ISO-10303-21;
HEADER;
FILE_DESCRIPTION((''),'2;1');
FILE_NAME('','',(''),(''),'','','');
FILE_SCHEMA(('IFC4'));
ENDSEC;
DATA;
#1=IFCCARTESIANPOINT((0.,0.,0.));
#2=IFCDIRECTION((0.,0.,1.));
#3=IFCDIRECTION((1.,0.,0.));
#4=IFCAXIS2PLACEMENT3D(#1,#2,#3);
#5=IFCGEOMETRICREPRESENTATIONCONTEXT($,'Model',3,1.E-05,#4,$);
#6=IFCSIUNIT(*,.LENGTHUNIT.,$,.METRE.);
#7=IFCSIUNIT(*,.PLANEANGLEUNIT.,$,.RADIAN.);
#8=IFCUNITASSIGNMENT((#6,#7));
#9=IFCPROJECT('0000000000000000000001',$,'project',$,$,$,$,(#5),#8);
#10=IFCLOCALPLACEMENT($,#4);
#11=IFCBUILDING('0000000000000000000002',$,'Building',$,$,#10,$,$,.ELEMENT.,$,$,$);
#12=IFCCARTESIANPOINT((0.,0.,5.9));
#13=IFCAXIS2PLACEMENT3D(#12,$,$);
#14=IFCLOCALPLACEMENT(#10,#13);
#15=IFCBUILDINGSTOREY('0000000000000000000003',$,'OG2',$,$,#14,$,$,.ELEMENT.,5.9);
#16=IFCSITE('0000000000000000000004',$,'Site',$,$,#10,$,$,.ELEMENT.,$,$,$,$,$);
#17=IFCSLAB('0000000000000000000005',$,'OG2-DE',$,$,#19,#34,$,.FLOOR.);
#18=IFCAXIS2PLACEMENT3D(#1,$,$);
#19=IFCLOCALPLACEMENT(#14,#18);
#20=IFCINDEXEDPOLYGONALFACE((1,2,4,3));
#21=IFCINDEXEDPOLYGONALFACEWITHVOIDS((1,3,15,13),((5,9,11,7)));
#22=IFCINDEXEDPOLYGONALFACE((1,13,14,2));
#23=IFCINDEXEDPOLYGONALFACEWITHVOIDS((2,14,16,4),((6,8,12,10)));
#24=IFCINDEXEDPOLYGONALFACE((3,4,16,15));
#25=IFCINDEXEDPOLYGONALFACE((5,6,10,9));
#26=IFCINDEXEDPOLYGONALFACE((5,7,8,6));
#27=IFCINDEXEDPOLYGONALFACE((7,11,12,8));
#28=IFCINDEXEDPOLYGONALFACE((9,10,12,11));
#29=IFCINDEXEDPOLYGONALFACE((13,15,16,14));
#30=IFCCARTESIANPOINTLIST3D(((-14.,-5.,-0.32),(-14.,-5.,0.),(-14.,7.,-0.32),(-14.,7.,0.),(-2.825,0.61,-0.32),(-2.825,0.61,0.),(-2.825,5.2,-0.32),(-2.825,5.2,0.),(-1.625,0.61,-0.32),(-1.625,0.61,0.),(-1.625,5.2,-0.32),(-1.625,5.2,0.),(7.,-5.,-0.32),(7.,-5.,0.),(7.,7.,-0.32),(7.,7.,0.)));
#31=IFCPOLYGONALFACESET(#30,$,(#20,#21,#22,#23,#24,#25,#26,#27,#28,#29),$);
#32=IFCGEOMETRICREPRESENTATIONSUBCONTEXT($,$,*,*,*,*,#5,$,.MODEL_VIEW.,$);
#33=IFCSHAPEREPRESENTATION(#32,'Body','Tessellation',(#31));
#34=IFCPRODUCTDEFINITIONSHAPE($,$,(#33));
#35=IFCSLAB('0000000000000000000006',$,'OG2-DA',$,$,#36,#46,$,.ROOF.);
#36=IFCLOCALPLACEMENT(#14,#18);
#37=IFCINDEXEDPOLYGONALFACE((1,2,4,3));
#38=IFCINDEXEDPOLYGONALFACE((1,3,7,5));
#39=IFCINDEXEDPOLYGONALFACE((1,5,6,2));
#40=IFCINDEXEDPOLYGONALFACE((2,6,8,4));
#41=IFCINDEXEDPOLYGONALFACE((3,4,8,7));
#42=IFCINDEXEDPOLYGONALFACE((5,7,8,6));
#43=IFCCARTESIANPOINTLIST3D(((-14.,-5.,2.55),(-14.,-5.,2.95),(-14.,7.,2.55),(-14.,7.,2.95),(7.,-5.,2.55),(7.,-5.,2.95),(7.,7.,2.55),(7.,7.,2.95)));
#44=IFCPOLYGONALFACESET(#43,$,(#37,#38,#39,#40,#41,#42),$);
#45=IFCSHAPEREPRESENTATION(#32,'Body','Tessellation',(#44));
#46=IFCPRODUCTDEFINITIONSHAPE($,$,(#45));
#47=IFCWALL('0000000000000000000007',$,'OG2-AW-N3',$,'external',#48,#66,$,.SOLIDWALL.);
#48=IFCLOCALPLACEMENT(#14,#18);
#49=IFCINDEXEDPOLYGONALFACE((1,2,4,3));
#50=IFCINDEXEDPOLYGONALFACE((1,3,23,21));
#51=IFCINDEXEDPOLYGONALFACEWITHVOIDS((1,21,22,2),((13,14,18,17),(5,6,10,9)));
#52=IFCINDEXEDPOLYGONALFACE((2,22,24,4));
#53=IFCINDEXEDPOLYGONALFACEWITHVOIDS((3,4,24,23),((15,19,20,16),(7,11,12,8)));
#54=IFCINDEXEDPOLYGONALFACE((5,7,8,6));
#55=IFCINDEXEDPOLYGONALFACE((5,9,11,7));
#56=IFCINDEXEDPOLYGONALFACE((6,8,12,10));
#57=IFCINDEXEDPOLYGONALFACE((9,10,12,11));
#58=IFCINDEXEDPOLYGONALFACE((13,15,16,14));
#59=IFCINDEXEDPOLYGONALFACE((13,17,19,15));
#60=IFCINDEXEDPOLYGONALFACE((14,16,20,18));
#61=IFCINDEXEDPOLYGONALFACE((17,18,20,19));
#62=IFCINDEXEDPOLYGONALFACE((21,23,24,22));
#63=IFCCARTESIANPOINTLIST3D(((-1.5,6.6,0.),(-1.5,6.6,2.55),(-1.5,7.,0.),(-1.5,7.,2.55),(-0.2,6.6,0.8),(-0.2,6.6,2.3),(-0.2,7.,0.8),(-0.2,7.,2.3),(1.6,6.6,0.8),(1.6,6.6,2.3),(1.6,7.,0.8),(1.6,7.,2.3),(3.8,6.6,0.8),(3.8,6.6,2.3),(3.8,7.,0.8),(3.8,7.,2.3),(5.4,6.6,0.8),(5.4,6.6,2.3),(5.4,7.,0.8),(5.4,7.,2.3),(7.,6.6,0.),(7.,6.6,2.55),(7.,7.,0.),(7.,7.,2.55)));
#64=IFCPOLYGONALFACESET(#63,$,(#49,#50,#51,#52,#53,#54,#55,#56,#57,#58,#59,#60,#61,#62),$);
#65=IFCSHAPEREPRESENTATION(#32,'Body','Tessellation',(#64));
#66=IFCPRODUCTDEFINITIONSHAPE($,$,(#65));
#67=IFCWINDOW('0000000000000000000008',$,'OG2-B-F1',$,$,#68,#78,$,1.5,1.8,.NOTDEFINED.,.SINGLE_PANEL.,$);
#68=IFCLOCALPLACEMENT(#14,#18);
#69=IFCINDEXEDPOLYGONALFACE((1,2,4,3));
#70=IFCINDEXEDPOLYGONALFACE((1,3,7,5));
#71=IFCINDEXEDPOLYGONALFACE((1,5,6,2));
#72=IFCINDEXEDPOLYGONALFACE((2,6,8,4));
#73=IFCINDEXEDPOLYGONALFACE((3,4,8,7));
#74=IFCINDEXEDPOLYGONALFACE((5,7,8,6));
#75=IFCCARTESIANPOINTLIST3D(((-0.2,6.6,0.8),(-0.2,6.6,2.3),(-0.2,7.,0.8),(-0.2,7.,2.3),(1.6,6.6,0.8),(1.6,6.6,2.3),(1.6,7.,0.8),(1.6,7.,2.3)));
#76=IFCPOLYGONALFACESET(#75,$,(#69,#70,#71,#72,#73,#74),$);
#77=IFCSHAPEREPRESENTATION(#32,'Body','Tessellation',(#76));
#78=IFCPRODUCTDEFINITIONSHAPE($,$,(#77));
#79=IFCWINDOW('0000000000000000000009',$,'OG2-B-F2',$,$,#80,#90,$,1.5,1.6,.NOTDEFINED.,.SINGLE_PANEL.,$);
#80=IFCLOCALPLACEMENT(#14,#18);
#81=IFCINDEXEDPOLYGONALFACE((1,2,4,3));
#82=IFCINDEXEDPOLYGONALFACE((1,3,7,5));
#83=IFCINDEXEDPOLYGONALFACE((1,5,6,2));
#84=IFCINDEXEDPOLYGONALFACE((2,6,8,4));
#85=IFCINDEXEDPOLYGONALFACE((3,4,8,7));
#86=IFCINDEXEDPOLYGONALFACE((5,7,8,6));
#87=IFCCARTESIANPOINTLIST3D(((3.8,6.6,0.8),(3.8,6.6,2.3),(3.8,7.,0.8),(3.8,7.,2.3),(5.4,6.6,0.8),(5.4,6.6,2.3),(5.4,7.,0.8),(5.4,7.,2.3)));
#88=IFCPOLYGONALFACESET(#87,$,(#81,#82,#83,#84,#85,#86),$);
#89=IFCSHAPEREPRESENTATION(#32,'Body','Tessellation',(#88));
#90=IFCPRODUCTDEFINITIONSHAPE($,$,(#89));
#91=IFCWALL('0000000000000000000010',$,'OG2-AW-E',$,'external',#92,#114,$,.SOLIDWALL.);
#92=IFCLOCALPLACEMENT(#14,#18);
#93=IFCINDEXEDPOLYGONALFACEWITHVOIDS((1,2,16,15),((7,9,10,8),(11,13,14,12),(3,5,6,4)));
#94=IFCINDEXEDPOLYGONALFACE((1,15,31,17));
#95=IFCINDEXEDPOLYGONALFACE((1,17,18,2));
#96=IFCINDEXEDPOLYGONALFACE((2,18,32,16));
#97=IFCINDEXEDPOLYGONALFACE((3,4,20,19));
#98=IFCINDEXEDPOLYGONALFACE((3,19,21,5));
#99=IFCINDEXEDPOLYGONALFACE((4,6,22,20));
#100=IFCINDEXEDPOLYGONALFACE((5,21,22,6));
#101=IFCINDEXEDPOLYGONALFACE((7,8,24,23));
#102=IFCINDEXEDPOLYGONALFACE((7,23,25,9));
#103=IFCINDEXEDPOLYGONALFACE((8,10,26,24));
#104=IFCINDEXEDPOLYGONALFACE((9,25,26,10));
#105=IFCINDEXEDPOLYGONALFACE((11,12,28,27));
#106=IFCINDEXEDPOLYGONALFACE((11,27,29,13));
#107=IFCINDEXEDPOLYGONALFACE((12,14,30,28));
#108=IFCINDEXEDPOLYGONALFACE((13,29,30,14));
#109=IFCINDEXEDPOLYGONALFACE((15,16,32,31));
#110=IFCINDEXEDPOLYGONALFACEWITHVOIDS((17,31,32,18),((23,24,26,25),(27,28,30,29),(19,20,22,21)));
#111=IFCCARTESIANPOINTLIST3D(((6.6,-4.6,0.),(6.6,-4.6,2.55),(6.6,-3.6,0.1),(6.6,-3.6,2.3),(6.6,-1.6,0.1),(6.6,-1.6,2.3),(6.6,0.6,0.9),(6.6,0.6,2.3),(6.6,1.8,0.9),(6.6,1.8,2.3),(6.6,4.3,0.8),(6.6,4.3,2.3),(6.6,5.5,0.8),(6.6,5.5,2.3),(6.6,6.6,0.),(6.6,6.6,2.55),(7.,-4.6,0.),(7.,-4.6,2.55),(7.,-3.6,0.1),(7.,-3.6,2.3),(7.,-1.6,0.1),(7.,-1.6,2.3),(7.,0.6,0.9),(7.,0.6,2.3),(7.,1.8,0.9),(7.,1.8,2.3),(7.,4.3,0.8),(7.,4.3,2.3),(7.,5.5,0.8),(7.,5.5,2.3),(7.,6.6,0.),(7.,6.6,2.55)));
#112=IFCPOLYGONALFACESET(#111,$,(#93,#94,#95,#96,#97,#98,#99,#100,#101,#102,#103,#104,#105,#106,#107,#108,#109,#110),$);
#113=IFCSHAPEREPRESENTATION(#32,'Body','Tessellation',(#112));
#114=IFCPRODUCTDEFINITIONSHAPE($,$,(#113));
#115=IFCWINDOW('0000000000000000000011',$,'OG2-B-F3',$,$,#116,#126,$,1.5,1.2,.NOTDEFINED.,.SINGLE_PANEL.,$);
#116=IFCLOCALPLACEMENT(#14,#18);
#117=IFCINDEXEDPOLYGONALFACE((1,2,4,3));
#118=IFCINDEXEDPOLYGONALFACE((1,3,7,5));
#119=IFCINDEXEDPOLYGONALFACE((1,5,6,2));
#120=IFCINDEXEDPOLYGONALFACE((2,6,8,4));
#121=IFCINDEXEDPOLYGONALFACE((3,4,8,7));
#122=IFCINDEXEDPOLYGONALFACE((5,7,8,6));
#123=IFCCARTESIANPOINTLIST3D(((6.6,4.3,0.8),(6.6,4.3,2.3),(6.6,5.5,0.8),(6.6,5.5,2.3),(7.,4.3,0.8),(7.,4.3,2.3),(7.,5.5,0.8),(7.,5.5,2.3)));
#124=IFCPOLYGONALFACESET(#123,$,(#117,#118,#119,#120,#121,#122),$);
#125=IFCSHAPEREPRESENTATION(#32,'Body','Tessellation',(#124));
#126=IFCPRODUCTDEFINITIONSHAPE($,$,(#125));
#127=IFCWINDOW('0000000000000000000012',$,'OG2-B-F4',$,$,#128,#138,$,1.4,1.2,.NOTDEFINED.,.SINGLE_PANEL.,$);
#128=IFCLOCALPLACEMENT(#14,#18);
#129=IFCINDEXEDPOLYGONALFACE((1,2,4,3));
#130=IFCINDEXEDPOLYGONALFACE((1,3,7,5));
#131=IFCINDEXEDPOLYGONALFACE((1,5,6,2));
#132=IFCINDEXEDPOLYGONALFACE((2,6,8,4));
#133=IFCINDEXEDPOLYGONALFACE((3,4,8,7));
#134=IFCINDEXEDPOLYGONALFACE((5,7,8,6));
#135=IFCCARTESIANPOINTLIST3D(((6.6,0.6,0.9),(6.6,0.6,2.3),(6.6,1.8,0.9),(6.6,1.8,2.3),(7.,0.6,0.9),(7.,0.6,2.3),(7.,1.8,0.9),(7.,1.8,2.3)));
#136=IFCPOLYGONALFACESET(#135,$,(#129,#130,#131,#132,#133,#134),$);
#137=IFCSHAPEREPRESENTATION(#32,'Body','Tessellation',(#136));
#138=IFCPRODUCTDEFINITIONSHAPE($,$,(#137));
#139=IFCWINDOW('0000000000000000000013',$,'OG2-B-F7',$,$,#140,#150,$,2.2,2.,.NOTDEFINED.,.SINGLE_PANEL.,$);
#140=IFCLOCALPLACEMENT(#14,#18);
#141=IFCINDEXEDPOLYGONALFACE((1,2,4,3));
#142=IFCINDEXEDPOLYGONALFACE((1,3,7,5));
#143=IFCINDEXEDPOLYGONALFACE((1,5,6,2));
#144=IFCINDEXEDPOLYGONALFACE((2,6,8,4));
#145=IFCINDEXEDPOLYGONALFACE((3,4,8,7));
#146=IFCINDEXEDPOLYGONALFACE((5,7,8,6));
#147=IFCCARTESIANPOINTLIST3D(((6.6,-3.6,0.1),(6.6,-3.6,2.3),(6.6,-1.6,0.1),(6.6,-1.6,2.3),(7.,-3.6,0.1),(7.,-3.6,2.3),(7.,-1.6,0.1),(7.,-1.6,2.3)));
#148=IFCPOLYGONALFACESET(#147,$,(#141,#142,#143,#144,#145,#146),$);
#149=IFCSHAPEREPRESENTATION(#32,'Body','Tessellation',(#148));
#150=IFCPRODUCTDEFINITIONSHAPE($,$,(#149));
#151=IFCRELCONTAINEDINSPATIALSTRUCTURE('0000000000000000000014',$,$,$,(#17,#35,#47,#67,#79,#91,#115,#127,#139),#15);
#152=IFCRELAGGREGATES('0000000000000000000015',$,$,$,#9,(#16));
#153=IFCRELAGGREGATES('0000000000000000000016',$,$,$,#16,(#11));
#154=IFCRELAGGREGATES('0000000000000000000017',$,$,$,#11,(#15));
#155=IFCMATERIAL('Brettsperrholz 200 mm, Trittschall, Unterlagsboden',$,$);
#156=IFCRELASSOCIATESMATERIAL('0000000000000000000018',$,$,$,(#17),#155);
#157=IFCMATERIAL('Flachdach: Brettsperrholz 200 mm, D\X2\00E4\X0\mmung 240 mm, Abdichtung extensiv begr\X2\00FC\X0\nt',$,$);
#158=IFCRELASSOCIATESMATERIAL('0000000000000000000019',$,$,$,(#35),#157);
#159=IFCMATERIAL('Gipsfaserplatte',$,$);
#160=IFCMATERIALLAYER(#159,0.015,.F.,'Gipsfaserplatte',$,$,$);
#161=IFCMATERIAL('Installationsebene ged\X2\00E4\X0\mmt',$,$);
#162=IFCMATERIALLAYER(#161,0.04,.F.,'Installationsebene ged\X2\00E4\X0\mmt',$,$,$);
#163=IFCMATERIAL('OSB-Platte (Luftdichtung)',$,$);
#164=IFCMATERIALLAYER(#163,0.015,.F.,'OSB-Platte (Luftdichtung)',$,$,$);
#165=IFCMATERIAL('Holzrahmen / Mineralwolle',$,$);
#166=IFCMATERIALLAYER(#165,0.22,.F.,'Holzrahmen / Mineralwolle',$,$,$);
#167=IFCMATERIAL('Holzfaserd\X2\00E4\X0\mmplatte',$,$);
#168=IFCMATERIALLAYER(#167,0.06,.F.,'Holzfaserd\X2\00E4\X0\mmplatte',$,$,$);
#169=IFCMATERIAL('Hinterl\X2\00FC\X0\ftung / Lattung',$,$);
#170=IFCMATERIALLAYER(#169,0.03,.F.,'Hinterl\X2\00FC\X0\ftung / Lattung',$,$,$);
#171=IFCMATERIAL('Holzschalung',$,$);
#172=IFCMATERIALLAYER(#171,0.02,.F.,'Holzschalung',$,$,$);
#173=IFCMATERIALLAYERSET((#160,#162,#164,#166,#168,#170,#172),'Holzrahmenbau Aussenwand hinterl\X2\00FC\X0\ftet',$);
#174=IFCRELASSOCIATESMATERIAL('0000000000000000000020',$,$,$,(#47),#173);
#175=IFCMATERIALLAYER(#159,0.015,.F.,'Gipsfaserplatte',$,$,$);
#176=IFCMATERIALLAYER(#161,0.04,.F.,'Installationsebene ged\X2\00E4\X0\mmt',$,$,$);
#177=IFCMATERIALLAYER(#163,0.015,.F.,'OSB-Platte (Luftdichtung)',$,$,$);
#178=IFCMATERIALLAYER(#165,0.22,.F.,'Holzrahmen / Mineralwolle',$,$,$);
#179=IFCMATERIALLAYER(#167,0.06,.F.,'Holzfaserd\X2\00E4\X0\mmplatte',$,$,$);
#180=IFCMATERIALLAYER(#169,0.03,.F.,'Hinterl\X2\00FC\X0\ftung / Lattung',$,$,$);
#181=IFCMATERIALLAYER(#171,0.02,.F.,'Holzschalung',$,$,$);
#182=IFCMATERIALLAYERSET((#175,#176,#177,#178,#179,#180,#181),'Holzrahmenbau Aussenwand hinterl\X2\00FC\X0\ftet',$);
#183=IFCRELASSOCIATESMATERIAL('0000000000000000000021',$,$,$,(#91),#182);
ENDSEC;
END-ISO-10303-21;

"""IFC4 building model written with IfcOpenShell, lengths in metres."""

from ifc_helpers import new_model, si_unit, frame, frame_2d, origin, origin_with_axes, origin_2d, place, context, subcontext, project, spatial, polyline, rectangle, outline, extrude, material, layer, layer_set, element, fill, save


model = new_model("IFC4")

# Units and contexts
model_context = context("Model", 3, precision=1e-05, world=origin_with_axes())
sub_context = subcontext(model_context, None, None, "MODEL_VIEW")
ifc_project = project(units=[si_unit("LENGTHUNIT", "METRE"), si_unit("PLANEANGLEUNIT", "RADIAN")], contexts=[model_context])

# Site, building, storey
placement = place(None, origin_with_axes())
site = spatial("IfcSite", under=ifc_project, at=placement, Name="Site", CompositionType="ELEMENT")
building = spatial("IfcBuilding", under=site, at=placement, Name="Building", CompositionType="ELEMENT")
storey_placement = place(placement, frame((0.0, 0.0, 5.9)))
storey = spatial("IfcBuildingStorey", under=building, at=storey_placement, Name="OG2", CompositionType="ELEMENT", Elevation=5.9)

# Slab, opening
ifc_material_1 = material(Name="Brettsperrholz 200 mm, Trittschall, Unterlagsboden")
slab_1_placement = place(storey_placement, frame((0.0, 0.0, -0.32)))
slab_1 = element("IfcSlab", 1, at=slab_1_placement, inside=storey, material=ifc_material_1, Name="OG2-DE", PredefinedType="FLOOR", context=sub_context, shape_type="SweptSolid", body=[
    extrude(outline(polyline([(-14.0, -5.0), (7.0, -5.0), (7.0, 7.0), (-14.0, 7.0), (-14.0, -5.0)])), origin(), (0.0, 0.0, 1.0), 0.32),
])
opening_1_placement = place(slab_1_placement, frame((-2.225, 2.905, 0.0)))
element("IfcOpeningElement", 2, at=opening_1_placement, cuts=slab_1, PredefinedType="OPENING", context=sub_context, shape_type="SweptSolid", body=[
    extrude(rectangle(XDim=1.2, YDim=4.59, at=origin_2d()), origin(), (0.0, 0.0, 1.0), 0.42),
])

# Slab
ifc_material_2 = material(Name="Flachdach: Brettsperrholz 200 mm, Dämmung 240 mm, Abdichtung extensiv begrünt")
slab_2_placement = place(storey_placement, frame((0.0, 0.0, 2.55)))
element("IfcSlab", 3, at=slab_2_placement, inside=storey, material=ifc_material_2, Name="OG2-DA", PredefinedType="ROOF", context=sub_context, shape_type="SweptSolid", body=[
    extrude(outline(polyline([(-14.0, -5.0), (7.0, -5.0), (7.0, 7.0), (-14.0, 7.0), (-14.0, -5.0)])), origin(), (0.0, 0.0, 1.0), 0.4),
])

# Walls, openings, windows
ifc_material_3 = material(Name="Gipsfaserplatte")
ifc_layer_1 = layer(ifc_material_3, 0.015, ventilated=False, Name="Gipsfaserplatte")
ifc_material_4 = material(Name="Installationsebene gedämmt")
ifc_layer_2 = layer(ifc_material_4, 0.04, ventilated=False, Name="Installationsebene gedämmt")
ifc_material_5 = material(Name="OSB-Platte (Luftdichtung)")
ifc_layer_3 = layer(ifc_material_5, 0.015, ventilated=False, Name="OSB-Platte (Luftdichtung)")
ifc_material_6 = material(Name="Holzrahmen / Mineralwolle")
ifc_layer_4 = layer(ifc_material_6, 0.22, ventilated=False, Name="Holzrahmen / Mineralwolle")
ifc_material_7 = material(Name="Holzfaserdämmplatte")
ifc_layer_5 = layer(ifc_material_7, 0.06, ventilated=False, Name="Holzfaserdämmplatte")
ifc_material_8 = material(Name="Hinterlüftung / Lattung")
ifc_layer_6 = layer(ifc_material_8, 0.03, ventilated=False, Name="Hinterlüftung / Lattung")
ifc_material_9 = material(Name="Holzschalung")
ifc_layer_7 = layer(ifc_material_9, 0.02, ventilated=False, Name="Holzschalung")
ifc_layer_set_1 = layer_set([ifc_layer_1, ifc_layer_2, ifc_layer_3, ifc_layer_4, ifc_layer_5, ifc_layer_6, ifc_layer_7], Name="Holzrahmenbau Aussenwand hinterlüftet")
wall_1_placement = place(storey_placement, frame((-1.5, 6.8, 0.0), z_axis=(0.0, 0.0, 1.0), x_axis=(1.0, 0.0, 0.0)))
wall_1 = element("IfcWall", 4, at=wall_1_placement, inside=storey, material=ifc_layer_set_1, Name="OG2-AW-N3", ObjectType="external", PredefinedType="SOLIDWALL", context=sub_context, shape_type="SweptSolid", body=[
    extrude(rectangle(XDim=8.5, YDim=0.4, at=frame_2d((4.25, 0.0))), origin(), (0.0, 0.0, 1.0), 2.55),
])
opening_2_placement = place(wall_1_placement, frame((2.2, 0.25, 0.8), z_axis=(0.0, -1.0, 0.0), x_axis=(1.0, 0.0, 0.0)))
opening_2 = element("IfcOpeningElement", 5, at=opening_2_placement, cuts=wall_1, PredefinedType="OPENING", context=sub_context, shape_type="SweptSolid", body=[
    extrude(rectangle(XDim=1.8, YDim=1.5, at=frame_2d((0.0, 0.75))), origin(), (0.0, 0.0, 1.0), 0.5),
])
opening_3_placement = place(wall_1_placement, frame((6.1, 0.25, 0.8), z_axis=(0.0, -1.0, 0.0), x_axis=(1.0, 0.0, 0.0)))
opening_3 = element("IfcOpeningElement", 6, at=opening_3_placement, cuts=wall_1, PredefinedType="OPENING", context=sub_context, shape_type="SweptSolid", body=[
    extrude(rectangle(XDim=1.6, YDim=1.5, at=frame_2d((0.0, 0.75))), origin(), (0.0, 0.0, 1.0), 0.5),
])
window_1_placement = place(wall_1_placement, frame((2.2, 0.2, 0.8), z_axis=(0.0, -1.0, 0.0), x_axis=(1.0, 0.0, 0.0)))
window_1 = element("IfcWindow", 7, at=window_1_placement, inside=storey, Name="OG2-B-F1", OverallHeight=1.5, OverallWidth=1.8, PartitioningType="SINGLE_PANEL", PredefinedType="NOTDEFINED", context=sub_context, shape_type="SweptSolid", body=[
    extrude(rectangle(XDim=1.8, YDim=1.5, at=frame_2d((0.0, 0.75))), origin(), (0.0, 0.0, 1.0), 0.4),
])
fill(opening_2, window_1)
window_2_placement = place(wall_1_placement, frame((6.1, 0.2, 0.8), z_axis=(0.0, -1.0, 0.0), x_axis=(1.0, 0.0, 0.0)))
window_2 = element("IfcWindow", 8, at=window_2_placement, inside=storey, Name="OG2-B-F2", OverallHeight=1.5, OverallWidth=1.6, PartitioningType="SINGLE_PANEL", PredefinedType="NOTDEFINED", context=sub_context, shape_type="SweptSolid", body=[
    extrude(rectangle(XDim=1.6, YDim=1.5, at=frame_2d((0.0, 0.75))), origin(), (0.0, 0.0, 1.0), 0.4),
])
fill(opening_3, window_2)
ifc_layer_8 = layer(ifc_material_3, 0.015, ventilated=False, Name="Gipsfaserplatte")
ifc_layer_9 = layer(ifc_material_4, 0.04, ventilated=False, Name="Installationsebene gedämmt")
ifc_layer_10 = layer(ifc_material_5, 0.015, ventilated=False, Name="OSB-Platte (Luftdichtung)")
ifc_layer_11 = layer(ifc_material_6, 0.22, ventilated=False, Name="Holzrahmen / Mineralwolle")
ifc_layer_12 = layer(ifc_material_7, 0.06, ventilated=False, Name="Holzfaserdämmplatte")
ifc_layer_13 = layer(ifc_material_8, 0.03, ventilated=False, Name="Hinterlüftung / Lattung")
ifc_layer_14 = layer(ifc_material_9, 0.02, ventilated=False, Name="Holzschalung")
ifc_layer_set_2 = layer_set([ifc_layer_8, ifc_layer_9, ifc_layer_10, ifc_layer_11, ifc_layer_12, ifc_layer_13, ifc_layer_14], Name="Holzrahmenbau Aussenwand hinterlüftet")
wall_2_placement = place(storey_placement, frame((6.8, 6.6, 0.0), z_axis=(0.0, 0.0, 1.0), x_axis=(0.0, -1.0, 0.0)))
wall_2 = element("IfcWall", 9, at=wall_2_placement, inside=storey, material=ifc_layer_set_2, Name="OG2-AW-E", ObjectType="external", PredefinedType="SOLIDWALL", context=sub_context, shape_type="SweptSolid", body=[
    extrude(rectangle(XDim=11.2, YDim=0.4, at=frame_2d((5.6, 0.0))), origin(), (0.0, 0.0, 1.0), 2.55),
])
opening_4_placement = place(wall_2_placement, frame((1.7, 0.25, 0.8), z_axis=(0.0, -1.0, 0.0), x_axis=(1.0, 0.0, 0.0)))
opening_4 = element("IfcOpeningElement", 10, at=opening_4_placement, cuts=wall_2, PredefinedType="OPENING", context=sub_context, shape_type="SweptSolid", body=[
    extrude(rectangle(XDim=1.2, YDim=1.5, at=frame_2d((0.0, 0.75))), origin(), (0.0, 0.0, 1.0), 0.5),
])
opening_5_placement = place(wall_2_placement, frame((5.4, 0.25, 0.9), z_axis=(0.0, -1.0, 0.0), x_axis=(1.0, 0.0, 0.0)))
opening_5 = element("IfcOpeningElement", 11, at=opening_5_placement, cuts=wall_2, PredefinedType="OPENING", context=sub_context, shape_type="SweptSolid", body=[
    extrude(rectangle(XDim=1.2, YDim=1.4, at=frame_2d((0.0, 0.7))), origin(), (0.0, 0.0, 1.0), 0.5),
])
opening_6_placement = place(wall_2_placement, frame((9.2, 0.25, 0.1), z_axis=(0.0, -1.0, 0.0), x_axis=(1.0, 0.0, 0.0)))
opening_6 = element("IfcOpeningElement", 12, at=opening_6_placement, cuts=wall_2, PredefinedType="OPENING", context=sub_context, shape_type="SweptSolid", body=[
    extrude(rectangle(XDim=2.0, YDim=2.2, at=frame_2d((0.0, 1.1))), origin(), (0.0, 0.0, 1.0), 0.5),
])
window_3_placement = place(wall_2_placement, frame((1.7, 0.2, 0.8), z_axis=(0.0, -1.0, 0.0), x_axis=(1.0, 0.0, 0.0)))
window_3 = element("IfcWindow", 13, at=window_3_placement, inside=storey, Name="OG2-B-F3", OverallHeight=1.5, OverallWidth=1.2, PartitioningType="SINGLE_PANEL", PredefinedType="NOTDEFINED", context=sub_context, shape_type="SweptSolid", body=[
    extrude(rectangle(XDim=1.2, YDim=1.5, at=frame_2d((0.0, 0.75))), origin(), (0.0, 0.0, 1.0), 0.4),
])
fill(opening_4, window_3)
window_4_placement = place(wall_2_placement, frame((5.4, 0.2, 0.9), z_axis=(0.0, -1.0, 0.0), x_axis=(1.0, 0.0, 0.0)))
window_4 = element("IfcWindow", 14, at=window_4_placement, inside=storey, Name="OG2-B-F4", OverallHeight=1.4, OverallWidth=1.2, PartitioningType="SINGLE_PANEL", PredefinedType="NOTDEFINED", context=sub_context, shape_type="SweptSolid", body=[
    extrude(rectangle(XDim=1.2, YDim=1.4, at=frame_2d((0.0, 0.7))), origin(), (0.0, 0.0, 1.0), 0.4),
])
fill(opening_5, window_4)
window_5_placement = place(wall_2_placement, frame((9.2, 0.2, 0.1), z_axis=(0.0, -1.0, 0.0), x_axis=(1.0, 0.0, 0.0)))
window_5 = element("IfcWindow", 15, at=window_5_placement, inside=storey, Name="OG2-B-F7", OverallHeight=2.2, OverallWidth=2.0, PartitioningType="SINGLE_PANEL", PredefinedType="NOTDEFINED", context=sub_context, shape_type="SweptSolid", body=[
    extrude(rectangle(XDim=2.0, YDim=2.2, at=frame_2d((0.0, 1.1))), origin(), (0.0, 0.0, 1.0), 0.4),
])
fill(opening_6, window_5)

save(model, "model.ifc")
